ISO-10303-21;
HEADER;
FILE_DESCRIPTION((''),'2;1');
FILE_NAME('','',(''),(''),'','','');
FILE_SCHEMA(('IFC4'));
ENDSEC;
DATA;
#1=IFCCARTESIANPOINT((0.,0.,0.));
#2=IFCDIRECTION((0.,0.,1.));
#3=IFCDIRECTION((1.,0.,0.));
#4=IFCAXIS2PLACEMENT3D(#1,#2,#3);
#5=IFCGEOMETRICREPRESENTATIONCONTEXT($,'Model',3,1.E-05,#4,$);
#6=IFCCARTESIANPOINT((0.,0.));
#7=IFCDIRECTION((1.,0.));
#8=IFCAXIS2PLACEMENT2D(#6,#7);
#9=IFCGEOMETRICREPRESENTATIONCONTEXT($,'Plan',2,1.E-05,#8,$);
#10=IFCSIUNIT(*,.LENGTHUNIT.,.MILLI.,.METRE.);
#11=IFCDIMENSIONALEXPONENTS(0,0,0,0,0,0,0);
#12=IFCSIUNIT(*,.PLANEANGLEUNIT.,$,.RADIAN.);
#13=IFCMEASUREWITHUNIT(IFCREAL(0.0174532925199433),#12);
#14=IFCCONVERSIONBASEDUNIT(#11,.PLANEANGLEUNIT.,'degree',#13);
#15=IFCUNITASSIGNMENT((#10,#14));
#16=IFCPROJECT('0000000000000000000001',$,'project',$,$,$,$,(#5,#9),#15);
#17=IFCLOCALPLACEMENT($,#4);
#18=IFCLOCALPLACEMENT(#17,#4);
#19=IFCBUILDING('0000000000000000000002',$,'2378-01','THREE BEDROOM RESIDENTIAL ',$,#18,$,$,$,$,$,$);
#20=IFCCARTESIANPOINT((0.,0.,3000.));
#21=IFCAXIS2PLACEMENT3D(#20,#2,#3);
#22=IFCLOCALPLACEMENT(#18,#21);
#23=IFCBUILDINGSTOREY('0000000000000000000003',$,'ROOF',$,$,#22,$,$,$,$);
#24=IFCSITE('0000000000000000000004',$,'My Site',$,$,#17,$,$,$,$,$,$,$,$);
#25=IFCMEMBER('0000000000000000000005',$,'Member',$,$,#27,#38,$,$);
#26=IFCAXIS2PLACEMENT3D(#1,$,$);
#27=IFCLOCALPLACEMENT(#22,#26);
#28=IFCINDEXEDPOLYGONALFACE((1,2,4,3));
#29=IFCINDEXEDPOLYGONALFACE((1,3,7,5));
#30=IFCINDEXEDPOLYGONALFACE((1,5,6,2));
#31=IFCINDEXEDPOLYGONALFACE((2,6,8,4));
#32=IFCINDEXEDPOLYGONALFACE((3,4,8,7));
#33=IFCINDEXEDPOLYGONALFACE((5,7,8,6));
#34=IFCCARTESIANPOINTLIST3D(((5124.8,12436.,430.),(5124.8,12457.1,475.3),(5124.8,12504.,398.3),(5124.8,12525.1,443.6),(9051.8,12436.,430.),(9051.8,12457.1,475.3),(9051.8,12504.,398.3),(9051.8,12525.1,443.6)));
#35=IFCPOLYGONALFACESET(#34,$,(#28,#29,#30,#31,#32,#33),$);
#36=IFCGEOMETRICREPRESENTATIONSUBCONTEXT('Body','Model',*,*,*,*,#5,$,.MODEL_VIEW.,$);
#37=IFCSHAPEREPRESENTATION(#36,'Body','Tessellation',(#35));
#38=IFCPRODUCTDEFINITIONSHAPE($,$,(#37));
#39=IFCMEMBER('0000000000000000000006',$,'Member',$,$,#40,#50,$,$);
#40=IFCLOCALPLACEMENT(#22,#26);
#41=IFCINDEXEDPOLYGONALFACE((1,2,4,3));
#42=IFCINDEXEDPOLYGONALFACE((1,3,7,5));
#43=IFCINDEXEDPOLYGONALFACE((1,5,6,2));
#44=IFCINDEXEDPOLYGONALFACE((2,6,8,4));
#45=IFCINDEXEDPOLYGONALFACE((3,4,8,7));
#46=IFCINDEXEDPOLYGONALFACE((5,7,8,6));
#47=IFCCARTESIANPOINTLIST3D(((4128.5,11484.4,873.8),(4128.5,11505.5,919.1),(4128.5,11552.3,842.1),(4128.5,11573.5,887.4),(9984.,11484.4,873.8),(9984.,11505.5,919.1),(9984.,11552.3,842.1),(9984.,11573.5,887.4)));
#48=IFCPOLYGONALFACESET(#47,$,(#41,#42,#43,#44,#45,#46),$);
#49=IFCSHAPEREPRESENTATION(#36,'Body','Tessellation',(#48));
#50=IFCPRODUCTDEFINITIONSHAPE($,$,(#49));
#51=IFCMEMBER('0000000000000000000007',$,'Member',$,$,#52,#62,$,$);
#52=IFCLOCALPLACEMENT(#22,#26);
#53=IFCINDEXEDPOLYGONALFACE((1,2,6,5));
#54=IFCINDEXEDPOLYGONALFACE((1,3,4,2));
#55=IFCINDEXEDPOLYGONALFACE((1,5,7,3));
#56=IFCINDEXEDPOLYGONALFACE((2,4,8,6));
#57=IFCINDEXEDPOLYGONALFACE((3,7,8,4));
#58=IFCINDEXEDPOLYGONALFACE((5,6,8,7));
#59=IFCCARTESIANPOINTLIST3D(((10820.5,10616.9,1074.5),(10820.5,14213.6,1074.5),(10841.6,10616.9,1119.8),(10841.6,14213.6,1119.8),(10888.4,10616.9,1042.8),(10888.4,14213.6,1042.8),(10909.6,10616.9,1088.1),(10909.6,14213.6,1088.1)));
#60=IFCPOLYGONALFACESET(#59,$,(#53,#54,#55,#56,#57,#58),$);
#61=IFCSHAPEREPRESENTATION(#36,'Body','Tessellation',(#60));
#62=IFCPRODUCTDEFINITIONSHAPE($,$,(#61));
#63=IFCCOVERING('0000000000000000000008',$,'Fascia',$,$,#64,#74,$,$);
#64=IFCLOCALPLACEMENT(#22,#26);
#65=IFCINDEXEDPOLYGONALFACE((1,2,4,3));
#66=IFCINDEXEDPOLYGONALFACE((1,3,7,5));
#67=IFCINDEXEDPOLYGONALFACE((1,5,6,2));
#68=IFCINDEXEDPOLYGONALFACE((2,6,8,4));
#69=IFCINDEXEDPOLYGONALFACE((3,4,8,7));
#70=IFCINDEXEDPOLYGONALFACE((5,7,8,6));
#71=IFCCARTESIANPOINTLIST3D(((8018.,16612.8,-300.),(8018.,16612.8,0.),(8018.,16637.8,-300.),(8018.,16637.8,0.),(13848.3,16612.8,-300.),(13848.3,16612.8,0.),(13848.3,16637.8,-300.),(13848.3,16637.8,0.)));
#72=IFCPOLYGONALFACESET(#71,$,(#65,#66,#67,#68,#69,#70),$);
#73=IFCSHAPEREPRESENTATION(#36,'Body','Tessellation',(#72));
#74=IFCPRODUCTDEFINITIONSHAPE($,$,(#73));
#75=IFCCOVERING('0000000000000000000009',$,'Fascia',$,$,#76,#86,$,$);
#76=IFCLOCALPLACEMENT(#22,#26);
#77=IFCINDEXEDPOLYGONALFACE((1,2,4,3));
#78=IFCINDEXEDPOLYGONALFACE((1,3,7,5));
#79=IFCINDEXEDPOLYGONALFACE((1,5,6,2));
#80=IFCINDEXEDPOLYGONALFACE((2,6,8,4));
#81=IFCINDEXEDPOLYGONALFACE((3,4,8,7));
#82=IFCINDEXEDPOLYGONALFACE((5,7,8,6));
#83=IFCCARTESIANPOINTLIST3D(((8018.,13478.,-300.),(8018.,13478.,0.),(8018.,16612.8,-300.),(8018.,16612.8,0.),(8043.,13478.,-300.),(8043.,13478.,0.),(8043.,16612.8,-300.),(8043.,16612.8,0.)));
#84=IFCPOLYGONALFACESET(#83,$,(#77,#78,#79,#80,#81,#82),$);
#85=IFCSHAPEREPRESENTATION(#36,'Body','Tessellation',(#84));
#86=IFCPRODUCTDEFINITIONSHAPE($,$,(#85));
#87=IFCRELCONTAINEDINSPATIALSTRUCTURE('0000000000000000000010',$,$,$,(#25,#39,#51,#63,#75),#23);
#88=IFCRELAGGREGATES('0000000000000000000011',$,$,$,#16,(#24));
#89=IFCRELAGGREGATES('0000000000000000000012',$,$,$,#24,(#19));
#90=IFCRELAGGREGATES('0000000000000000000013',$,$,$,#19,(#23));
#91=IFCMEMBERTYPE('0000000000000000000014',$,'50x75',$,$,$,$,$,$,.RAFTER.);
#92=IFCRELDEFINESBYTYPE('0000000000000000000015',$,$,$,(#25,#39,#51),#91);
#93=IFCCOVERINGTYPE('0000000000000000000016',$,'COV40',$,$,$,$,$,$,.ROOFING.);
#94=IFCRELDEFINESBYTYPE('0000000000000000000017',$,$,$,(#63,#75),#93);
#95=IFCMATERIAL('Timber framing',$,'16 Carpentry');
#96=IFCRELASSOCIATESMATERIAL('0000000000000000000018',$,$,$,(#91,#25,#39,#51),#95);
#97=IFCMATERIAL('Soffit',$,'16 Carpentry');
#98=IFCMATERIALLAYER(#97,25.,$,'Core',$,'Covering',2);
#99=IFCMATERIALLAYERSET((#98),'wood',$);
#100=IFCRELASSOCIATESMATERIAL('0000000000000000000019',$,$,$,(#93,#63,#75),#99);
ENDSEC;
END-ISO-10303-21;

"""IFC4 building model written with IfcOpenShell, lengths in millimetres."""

from ifc_helpers import new_model, entity, si_unit, converted_unit, frame, origin_with_axes, origin_2d_with_axis, place, context, subcontext, project, spatial, indexed_curve, rectangle, outline, extrude, material, layer, layer_set, layer_usage, material_profile, profile_set, profile_usage, type_object, element, save


model = new_model("IFC4")

# Units and contexts
model_context = context("Model", 3, precision=1e-05, world=origin_with_axes())
plan_context = context("Plan", 2, precision=1e-05, world=origin_2d_with_axis())
body_context = subcontext(model_context, "Body", "Model", "MODEL_VIEW")
ifc_project = project(units=[si_unit("LENGTHUNIT", "METRE", prefix="MILLI"), converted_unit("PLANEANGLEUNIT", "degree", entity("IfcReal", 0.0174532925199433), si_unit("PLANEANGLEUNIT", "RADIAN"), dimensions=[0, 0, 0, 0, 0, 0, 0])], contexts=[model_context, plan_context])

# Site, building, storey
site_placement = place(None, origin_with_axes())
site = spatial("IfcSite", under=ifc_project, at=site_placement, Name="My Site")
building_placement = place(site_placement, origin_with_axes())
building = spatial("IfcBuilding", under=site, at=building_placement, Name="2378-01", Description="THREE BEDROOM RESIDENTIAL ")
storey_placement = place(building_placement, frame((0.0, 0.0, 3000.0), z_axis=(0.0, 0.0, 1.0), x_axis=(1.0, 0.0, 0.0)))
storey = spatial("IfcBuildingStorey", under=building, at=storey_placement, Name="ROOF")

# Members
ifc_material_1 = material(Name="Timber framing", Category="16 Carpentry")
ifc_material_profile_1 = material_profile(ifc_material_1, rectangle(XDim=50.0, YDim=75.0), Name="Lumber2", Category="Substrate", Priority=2)
ifc_profile_set_1 = profile_set([ifc_material_profile_1])
member_type_1 = type_object("IfcMemberType", Name="50x75", PredefinedType="RAFTER", material=ifc_profile_set_1)
ifc_profile_usage_1 = profile_usage(ifc_profile_set_1, cardinal=5)
member_1_placement = place(storey_placement, frame((9051.8, 12480.5, 436.8), z_axis=(-1.0, 0.0, 0.0), x_axis=(0.0, -0.422618, -0.906308)))
element("IfcMember", 1, at=member_1_placement, inside=storey, type_object=member_type_1, material=ifc_profile_usage_1, Name="Member", context=body_context, shape_type="SweptSolid", body=[
    extrude(rectangle(XDim=50.0, YDim=75.0), origin_with_axes(), (0.0, 0.0, 1.0), 3927.0),
])
ifc_profile_usage_2 = profile_usage(ifc_profile_set_1, cardinal=5)
member_2_placement = place(storey_placement, frame((9984.0, 11528.9, 880.6), z_axis=(-1.0, 0.0, 0.0), x_axis=(0.0, -0.422618, -0.906308)))
element("IfcMember", 2, at=member_2_placement, inside=storey, type_object=member_type_1, material=ifc_profile_usage_2, Name="Member", context=body_context, shape_type="SweptSolid", body=[
    extrude(rectangle(XDim=50.0, YDim=75.0), origin_with_axes(), (0.0, 0.0, 1.0), 5855.5),
])
ifc_profile_usage_3 = profile_usage(ifc_profile_set_1, cardinal=5)
member_3_placement = place(storey_placement, frame((10865.0, 14213.6, 1081.3), z_axis=(0.0, -1.0, 0.0), x_axis=(0.422618, 0.0, 0.906308)))
element("IfcMember", 3, at=member_3_placement, inside=storey, type_object=member_type_1, material=ifc_profile_usage_3, Name="Member", context=body_context, shape_type="SweptSolid", body=[
    extrude(rectangle(XDim=50.0, YDim=75.0), origin_with_axes(), (0.0, 0.0, 1.0), 3596.8),
])

# Coverings
ifc_material_2 = material(Name="Soffit", Category="16 Carpentry")
ifc_layer = layer(ifc_material_2, 25.0, Name="Core", Category="Covering", Priority=2)
ifc_layer_set = layer_set([ifc_layer], Name="wood")
ifc_layer_usage_1 = layer_usage(ifc_layer_set, "AXIS2", "POSITIVE", 0.0)
covering_type = type_object("IfcCoveringType", Name="COV40", PredefinedType="ROOFING", material=ifc_layer_set)
covering_1_placement = place(storey_placement, frame((8018.0, 16612.8, -300.0), z_axis=(0.0, 0.0, 1.0), x_axis=(1.0, 0.0, 0.0)))
element("IfcCovering", 4, at=covering_1_placement, inside=storey, type_object=covering_type, material=ifc_layer_usage_1, Name="Fascia", context=body_context, shape_type="SweptSolid", body=[
    extrude(outline(indexed_curve([(0.0, 0.0), (0.0, 25.0), (5830.3, 25.0), (5830.3, 0.0), (0.0, 0.0)], self_intersect=False)), origin_with_axes(), (0.0, 0.0, 1.0), 300.0),
])
ifc_layer_usage_2 = layer_usage(ifc_layer_set, "AXIS2", "POSITIVE", 0.0)
covering_2_placement = place(storey_placement, frame((8018.0, 16612.8, -300.0), z_axis=(0.0, 0.0, 1.0), x_axis=(0.0, -1.0, 0.0)))
element("IfcCovering", 5, at=covering_2_placement, inside=storey, type_object=covering_type, material=ifc_layer_usage_2, Name="Fascia", context=body_context, shape_type="SweptSolid", body=[
    extrude(outline(indexed_curve([(0.0, 0.0), (0.0, 25.0), (3134.8, 25.0), (3134.8, 0.0), (0.0, 0.0)], self_intersect=False)), origin_with_axes(), (0.0, 0.0, 1.0), 300.0),
])

save(model, "model.ifc")
